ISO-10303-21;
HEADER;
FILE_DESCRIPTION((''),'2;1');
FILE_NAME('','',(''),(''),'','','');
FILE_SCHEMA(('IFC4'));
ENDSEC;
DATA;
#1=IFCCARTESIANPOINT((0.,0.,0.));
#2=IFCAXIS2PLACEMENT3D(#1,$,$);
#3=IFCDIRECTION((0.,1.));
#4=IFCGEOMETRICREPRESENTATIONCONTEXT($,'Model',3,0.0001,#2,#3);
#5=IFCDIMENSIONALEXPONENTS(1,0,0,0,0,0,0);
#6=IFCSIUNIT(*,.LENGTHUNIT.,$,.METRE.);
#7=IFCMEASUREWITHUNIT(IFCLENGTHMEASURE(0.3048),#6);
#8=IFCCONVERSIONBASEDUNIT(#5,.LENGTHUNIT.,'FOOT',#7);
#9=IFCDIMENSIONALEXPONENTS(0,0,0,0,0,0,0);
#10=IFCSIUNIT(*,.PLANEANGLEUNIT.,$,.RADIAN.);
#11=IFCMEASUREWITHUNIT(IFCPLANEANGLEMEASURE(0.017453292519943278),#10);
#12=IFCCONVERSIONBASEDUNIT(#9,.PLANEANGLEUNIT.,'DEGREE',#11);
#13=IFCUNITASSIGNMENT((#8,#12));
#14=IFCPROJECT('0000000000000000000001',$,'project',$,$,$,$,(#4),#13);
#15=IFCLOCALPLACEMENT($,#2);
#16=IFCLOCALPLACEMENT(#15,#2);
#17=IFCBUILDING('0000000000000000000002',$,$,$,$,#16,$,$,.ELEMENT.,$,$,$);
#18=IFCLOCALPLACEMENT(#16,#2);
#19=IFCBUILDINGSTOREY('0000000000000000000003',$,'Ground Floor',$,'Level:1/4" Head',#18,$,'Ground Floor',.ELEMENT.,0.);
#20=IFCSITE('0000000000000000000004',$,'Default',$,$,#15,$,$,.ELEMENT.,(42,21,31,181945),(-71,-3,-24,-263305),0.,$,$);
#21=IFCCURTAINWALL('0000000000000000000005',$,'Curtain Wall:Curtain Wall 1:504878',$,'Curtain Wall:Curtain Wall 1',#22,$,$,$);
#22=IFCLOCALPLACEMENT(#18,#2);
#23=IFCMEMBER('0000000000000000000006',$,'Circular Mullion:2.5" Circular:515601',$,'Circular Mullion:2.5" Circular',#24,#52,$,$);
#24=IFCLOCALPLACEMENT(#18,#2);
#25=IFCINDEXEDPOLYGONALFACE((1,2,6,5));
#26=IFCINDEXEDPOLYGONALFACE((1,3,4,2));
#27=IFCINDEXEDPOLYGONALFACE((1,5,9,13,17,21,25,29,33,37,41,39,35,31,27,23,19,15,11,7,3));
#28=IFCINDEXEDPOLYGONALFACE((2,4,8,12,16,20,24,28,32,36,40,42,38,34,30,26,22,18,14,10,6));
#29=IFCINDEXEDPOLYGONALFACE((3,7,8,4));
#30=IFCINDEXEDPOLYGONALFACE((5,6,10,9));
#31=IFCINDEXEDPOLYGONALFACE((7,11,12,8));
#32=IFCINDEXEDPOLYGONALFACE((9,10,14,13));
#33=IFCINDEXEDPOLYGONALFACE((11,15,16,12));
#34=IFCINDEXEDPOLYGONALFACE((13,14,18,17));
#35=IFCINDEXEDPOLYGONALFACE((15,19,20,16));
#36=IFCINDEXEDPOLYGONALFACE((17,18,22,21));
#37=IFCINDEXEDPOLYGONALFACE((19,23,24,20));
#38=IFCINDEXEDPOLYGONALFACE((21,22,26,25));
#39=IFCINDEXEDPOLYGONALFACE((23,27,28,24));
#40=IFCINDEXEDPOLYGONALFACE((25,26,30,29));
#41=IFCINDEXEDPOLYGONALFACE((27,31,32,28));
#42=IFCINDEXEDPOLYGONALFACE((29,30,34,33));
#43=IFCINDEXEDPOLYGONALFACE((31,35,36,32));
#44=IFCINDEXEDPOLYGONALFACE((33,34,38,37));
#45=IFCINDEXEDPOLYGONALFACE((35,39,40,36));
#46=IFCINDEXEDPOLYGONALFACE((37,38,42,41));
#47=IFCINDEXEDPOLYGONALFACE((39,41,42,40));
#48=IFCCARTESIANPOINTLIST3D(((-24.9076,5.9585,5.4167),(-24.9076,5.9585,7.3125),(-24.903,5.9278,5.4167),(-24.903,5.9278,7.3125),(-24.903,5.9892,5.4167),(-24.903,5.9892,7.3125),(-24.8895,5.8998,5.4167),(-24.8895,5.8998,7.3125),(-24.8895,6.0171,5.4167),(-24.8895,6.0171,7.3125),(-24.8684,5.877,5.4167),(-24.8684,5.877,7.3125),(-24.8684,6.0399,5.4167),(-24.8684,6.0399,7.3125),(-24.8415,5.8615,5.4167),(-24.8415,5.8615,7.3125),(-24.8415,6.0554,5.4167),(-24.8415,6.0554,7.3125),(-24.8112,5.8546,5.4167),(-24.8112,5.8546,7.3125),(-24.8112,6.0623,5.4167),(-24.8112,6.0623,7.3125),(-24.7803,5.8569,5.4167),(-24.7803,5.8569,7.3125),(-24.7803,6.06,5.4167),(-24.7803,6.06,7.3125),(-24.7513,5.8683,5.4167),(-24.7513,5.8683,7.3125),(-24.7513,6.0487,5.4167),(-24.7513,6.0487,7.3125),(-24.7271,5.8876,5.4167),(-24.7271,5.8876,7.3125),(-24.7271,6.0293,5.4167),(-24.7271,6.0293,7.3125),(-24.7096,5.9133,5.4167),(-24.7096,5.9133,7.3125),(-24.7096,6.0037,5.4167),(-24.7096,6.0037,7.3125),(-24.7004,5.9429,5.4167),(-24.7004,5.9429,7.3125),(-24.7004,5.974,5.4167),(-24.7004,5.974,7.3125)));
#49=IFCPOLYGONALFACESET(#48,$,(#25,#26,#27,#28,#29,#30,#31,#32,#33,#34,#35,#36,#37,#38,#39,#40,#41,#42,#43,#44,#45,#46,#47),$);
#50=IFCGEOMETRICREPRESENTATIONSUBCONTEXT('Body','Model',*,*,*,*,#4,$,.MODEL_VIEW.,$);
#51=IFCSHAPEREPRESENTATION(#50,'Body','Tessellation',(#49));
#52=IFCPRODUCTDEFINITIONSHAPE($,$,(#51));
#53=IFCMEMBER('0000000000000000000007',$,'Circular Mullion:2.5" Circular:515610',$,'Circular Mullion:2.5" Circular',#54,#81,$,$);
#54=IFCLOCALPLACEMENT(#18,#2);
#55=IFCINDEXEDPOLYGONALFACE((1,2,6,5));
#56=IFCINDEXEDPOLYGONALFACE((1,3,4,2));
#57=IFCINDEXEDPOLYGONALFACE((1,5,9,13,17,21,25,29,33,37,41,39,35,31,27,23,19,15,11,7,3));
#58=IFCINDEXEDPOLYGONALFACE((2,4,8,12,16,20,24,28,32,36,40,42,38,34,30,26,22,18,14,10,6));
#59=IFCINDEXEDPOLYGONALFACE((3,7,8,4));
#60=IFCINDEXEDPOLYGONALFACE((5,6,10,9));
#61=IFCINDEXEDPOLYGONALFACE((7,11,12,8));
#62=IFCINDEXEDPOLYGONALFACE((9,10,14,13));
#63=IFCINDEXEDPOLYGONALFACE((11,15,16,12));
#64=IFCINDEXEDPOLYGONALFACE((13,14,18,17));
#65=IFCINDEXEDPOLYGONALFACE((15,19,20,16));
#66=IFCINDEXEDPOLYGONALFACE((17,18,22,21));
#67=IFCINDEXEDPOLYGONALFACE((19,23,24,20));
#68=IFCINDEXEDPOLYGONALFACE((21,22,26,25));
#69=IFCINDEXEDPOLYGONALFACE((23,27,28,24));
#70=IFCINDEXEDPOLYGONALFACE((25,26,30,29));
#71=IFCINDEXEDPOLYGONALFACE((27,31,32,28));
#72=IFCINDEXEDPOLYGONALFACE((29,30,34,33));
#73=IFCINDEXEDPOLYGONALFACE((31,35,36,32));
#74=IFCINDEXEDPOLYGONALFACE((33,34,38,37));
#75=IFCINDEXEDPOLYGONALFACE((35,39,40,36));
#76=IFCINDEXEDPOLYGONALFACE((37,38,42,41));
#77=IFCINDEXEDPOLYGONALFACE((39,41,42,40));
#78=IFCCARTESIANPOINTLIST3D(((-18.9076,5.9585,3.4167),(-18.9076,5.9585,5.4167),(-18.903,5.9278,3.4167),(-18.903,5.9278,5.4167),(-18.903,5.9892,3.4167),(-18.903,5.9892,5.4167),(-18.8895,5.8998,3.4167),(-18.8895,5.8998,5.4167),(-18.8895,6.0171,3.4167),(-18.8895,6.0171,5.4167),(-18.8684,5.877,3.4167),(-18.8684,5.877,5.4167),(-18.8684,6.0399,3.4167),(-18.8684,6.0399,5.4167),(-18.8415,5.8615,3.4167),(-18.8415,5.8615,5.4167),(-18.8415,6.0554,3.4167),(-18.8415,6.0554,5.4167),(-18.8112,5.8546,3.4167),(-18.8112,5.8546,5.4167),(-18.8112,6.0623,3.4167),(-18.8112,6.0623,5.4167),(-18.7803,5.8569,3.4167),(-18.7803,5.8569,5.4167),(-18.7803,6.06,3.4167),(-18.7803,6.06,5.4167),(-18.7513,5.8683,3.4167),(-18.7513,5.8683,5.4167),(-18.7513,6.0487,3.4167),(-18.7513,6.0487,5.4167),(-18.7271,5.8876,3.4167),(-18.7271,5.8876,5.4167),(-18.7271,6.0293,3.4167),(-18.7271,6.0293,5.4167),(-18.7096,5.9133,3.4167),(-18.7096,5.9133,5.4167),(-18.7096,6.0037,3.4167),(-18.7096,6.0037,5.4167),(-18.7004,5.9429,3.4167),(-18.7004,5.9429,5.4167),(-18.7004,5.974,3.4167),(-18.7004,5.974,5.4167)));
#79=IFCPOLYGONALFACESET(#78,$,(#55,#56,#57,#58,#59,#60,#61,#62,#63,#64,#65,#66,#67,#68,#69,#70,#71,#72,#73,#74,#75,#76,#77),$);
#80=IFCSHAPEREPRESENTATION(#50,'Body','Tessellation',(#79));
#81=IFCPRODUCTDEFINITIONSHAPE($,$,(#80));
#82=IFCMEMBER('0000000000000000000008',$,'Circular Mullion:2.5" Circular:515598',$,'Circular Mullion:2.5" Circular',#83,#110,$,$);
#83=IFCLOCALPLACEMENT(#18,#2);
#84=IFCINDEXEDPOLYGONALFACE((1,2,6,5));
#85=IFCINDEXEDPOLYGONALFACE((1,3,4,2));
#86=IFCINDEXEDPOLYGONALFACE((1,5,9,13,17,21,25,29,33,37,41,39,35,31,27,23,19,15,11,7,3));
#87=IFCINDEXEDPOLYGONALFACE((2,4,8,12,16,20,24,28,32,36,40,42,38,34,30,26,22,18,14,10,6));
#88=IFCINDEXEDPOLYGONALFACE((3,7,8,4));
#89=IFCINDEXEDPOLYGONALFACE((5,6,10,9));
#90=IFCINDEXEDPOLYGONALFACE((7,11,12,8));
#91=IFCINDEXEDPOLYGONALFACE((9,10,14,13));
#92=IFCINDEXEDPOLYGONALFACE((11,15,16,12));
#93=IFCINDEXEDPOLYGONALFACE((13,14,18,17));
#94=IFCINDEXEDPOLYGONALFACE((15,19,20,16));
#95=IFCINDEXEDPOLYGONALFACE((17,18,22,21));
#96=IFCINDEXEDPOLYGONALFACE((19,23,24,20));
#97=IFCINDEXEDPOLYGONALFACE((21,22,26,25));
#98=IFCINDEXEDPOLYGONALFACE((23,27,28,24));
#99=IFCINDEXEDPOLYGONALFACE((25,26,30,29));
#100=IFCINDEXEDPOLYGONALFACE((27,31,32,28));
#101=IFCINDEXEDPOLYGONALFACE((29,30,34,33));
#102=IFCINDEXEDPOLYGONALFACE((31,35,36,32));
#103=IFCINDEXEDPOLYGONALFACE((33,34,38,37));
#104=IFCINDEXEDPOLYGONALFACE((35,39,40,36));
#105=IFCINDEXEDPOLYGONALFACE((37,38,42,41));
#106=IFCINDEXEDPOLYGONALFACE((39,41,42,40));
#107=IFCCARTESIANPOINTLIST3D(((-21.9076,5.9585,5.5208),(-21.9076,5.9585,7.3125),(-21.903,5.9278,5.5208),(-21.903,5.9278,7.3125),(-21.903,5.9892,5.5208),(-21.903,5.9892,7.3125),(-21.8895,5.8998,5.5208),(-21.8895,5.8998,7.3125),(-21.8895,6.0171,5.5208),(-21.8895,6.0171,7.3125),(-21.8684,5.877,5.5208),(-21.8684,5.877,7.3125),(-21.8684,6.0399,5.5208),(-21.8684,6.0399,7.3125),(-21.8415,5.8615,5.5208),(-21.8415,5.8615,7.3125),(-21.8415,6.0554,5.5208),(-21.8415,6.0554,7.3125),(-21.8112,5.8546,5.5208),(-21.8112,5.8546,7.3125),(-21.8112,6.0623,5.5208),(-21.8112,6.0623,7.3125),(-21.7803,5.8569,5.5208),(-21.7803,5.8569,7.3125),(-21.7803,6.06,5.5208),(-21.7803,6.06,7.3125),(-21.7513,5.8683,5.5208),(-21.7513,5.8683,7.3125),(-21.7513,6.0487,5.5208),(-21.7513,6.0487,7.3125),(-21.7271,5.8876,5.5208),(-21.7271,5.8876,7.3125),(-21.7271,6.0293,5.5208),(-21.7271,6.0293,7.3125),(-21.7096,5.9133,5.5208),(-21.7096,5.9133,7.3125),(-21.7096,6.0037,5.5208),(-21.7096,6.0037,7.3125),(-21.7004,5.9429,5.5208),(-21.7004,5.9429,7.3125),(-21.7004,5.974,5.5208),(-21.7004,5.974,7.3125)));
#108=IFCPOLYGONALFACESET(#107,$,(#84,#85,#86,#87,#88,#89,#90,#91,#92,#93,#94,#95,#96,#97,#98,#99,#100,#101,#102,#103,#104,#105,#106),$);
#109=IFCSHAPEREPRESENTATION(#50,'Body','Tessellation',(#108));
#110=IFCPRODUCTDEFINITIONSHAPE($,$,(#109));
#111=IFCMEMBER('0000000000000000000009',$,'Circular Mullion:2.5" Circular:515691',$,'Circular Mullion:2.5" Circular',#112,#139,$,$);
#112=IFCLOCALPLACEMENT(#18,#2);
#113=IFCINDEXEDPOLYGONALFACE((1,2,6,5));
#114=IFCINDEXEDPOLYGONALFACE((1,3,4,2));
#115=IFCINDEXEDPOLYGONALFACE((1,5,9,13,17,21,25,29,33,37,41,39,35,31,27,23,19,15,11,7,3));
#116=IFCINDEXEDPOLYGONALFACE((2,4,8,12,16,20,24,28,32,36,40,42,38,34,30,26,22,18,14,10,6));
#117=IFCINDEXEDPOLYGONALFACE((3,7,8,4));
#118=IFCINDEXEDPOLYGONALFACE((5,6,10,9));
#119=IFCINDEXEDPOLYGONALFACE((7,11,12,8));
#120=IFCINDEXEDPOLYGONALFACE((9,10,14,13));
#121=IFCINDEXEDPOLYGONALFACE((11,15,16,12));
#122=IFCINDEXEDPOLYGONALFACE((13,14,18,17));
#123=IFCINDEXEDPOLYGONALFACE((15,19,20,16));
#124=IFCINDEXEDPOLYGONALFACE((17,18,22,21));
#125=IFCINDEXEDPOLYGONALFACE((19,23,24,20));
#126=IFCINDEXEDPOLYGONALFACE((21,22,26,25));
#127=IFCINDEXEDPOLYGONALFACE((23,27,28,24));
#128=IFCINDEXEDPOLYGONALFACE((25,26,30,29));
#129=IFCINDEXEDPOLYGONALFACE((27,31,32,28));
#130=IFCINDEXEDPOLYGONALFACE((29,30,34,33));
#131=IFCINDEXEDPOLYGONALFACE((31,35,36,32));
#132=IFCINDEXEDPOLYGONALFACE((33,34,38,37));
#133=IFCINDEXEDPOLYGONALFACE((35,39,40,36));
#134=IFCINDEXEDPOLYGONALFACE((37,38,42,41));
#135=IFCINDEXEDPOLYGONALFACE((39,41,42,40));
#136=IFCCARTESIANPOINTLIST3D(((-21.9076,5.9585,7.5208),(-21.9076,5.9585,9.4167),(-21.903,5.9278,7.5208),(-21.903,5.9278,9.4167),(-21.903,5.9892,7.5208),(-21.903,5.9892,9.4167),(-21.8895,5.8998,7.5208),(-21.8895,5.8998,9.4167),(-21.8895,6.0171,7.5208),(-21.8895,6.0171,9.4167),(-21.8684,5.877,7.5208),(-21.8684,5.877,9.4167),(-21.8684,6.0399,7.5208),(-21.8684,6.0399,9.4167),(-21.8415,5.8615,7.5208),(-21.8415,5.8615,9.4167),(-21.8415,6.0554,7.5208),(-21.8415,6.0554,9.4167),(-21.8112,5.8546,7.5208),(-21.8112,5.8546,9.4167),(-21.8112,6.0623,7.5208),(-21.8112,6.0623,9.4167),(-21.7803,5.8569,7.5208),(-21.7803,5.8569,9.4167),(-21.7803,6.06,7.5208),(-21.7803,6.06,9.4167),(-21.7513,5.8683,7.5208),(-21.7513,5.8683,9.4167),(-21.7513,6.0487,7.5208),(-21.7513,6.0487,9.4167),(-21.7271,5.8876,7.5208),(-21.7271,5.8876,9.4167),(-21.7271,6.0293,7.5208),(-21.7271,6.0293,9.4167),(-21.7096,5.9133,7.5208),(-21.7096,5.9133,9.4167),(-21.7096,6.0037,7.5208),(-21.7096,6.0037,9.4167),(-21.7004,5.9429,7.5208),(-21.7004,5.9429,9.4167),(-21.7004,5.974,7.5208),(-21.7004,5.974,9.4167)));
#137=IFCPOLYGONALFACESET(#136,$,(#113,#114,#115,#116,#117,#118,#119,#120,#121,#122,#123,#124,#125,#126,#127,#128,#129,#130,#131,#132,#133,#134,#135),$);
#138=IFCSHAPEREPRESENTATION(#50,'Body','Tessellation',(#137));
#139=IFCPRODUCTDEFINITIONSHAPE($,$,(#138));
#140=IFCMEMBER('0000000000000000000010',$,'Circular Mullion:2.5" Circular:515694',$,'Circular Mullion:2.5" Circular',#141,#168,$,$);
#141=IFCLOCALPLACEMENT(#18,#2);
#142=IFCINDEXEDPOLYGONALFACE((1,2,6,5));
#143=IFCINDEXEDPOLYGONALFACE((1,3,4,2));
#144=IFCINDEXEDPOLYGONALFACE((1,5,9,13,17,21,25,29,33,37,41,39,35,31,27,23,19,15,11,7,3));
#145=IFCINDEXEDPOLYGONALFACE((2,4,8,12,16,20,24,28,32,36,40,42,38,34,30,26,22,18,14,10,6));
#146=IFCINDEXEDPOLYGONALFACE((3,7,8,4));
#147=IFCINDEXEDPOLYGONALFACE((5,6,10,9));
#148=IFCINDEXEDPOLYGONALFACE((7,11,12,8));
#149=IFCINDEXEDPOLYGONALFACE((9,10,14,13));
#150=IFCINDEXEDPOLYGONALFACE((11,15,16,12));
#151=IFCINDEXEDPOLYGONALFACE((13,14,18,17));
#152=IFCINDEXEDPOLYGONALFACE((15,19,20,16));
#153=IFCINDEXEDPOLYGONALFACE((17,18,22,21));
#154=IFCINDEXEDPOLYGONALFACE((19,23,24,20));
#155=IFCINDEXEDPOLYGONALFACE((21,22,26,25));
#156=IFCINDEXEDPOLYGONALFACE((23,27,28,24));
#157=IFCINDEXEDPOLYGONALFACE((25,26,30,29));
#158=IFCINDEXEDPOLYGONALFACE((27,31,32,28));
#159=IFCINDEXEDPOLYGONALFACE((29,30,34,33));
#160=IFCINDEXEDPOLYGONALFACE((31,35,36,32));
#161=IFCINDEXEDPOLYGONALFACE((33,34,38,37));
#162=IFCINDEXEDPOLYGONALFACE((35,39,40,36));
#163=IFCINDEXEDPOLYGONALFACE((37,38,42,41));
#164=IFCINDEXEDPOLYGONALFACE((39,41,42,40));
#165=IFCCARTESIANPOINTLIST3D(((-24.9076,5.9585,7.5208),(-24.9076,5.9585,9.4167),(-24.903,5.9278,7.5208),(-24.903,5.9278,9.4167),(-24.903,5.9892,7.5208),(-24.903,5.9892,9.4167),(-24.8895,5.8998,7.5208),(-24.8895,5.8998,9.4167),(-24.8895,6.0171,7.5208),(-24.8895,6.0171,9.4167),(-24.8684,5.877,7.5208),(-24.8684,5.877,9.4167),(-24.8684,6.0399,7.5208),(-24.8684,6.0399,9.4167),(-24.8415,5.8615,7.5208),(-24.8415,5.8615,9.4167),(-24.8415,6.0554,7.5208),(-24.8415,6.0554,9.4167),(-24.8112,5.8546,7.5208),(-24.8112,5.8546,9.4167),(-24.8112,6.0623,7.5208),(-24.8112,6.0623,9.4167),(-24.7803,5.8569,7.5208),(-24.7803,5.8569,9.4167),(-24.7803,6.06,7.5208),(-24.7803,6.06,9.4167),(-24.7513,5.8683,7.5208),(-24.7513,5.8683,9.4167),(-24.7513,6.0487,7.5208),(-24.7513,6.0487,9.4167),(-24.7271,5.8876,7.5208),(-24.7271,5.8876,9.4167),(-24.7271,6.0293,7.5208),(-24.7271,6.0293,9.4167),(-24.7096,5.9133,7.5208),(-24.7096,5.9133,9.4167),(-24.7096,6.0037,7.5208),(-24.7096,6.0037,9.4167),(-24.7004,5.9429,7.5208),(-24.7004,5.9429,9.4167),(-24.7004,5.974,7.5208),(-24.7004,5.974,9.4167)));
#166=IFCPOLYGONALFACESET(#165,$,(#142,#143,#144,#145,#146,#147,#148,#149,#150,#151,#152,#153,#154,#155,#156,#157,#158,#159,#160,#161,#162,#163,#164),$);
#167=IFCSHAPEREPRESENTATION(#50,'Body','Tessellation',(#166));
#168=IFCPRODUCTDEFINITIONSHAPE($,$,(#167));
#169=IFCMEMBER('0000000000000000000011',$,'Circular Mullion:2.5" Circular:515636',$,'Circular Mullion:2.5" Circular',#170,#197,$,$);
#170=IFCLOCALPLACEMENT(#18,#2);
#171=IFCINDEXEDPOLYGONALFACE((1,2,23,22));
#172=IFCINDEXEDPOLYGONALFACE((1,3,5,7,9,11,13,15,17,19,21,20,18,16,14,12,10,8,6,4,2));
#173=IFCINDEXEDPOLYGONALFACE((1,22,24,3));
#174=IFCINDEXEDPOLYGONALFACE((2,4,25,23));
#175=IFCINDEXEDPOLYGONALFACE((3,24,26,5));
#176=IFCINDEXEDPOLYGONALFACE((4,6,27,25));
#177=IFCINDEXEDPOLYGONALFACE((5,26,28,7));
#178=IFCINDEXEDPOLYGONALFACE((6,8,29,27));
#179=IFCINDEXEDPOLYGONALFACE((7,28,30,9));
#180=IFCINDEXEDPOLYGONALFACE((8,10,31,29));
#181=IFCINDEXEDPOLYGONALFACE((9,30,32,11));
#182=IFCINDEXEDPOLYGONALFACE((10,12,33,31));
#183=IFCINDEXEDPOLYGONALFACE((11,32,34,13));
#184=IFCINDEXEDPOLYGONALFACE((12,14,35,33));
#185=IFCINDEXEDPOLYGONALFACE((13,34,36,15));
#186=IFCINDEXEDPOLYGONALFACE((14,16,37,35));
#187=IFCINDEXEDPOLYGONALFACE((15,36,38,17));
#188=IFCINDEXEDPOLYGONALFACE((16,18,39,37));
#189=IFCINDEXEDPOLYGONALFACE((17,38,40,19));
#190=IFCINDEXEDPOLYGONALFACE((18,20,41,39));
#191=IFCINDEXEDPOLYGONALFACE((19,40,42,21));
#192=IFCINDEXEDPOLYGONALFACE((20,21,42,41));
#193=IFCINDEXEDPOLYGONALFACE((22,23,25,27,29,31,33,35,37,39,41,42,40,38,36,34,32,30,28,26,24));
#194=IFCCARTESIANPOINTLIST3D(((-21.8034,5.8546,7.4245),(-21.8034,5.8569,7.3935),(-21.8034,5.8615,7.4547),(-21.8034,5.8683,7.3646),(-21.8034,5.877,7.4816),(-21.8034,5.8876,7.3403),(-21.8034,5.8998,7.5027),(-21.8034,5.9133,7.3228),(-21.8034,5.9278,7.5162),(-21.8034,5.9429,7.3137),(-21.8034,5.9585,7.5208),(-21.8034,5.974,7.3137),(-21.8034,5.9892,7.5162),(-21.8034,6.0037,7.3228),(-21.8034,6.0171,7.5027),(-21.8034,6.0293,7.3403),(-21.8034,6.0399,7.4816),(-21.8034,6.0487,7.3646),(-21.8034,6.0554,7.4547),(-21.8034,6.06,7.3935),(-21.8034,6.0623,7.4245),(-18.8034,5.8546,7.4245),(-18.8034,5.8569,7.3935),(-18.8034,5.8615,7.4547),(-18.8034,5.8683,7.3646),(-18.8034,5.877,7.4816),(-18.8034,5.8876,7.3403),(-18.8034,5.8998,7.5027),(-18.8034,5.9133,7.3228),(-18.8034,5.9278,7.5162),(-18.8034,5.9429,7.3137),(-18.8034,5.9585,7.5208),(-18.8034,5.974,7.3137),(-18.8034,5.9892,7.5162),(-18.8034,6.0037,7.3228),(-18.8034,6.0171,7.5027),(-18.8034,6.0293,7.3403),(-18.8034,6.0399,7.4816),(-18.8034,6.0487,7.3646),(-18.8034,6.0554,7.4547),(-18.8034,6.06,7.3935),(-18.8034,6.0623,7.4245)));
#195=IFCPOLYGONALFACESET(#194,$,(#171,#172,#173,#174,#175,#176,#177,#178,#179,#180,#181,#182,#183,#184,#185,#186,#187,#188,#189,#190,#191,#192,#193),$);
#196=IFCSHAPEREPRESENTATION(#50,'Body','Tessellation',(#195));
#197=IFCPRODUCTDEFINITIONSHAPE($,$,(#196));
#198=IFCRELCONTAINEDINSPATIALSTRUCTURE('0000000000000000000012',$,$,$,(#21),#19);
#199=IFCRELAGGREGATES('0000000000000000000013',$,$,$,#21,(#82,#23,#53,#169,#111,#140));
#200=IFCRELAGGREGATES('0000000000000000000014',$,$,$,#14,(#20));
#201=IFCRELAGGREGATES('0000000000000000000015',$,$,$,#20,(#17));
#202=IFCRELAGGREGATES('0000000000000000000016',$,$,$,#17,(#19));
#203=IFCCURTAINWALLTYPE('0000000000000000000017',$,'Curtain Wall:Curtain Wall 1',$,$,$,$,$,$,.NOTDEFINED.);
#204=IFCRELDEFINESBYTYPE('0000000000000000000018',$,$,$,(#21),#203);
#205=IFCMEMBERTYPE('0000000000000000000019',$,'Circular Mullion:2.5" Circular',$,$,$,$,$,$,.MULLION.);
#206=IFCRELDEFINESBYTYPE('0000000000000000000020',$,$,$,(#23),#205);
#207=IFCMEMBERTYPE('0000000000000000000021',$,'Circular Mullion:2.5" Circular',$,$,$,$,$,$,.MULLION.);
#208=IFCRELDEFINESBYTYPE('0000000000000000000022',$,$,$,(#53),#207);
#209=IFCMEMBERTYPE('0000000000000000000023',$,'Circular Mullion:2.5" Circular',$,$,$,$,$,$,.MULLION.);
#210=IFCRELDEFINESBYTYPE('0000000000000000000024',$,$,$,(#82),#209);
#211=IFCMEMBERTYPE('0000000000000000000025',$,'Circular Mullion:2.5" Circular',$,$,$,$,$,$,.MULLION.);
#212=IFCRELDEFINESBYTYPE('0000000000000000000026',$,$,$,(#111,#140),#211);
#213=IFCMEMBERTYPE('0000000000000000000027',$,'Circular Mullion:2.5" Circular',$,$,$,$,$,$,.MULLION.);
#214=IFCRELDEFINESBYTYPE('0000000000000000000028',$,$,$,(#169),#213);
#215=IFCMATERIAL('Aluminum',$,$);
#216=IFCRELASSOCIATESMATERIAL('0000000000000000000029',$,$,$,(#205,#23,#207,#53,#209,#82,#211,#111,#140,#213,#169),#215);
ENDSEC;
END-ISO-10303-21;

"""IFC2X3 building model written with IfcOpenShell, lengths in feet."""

from ifc_helpers import new_model, entity, si_unit, converted_unit, direction, frame, frame_2d, origin, place, context, subcontext, project, spatial, circle, extrude, source, transform, mapped, material, type_object, type_shapes, element, aggregate, save


model = new_model("IFC2X3")

# Units and contexts
model_context = context("Model", 3, precision=0.0001, world=origin(), true_north=direction((0.0, 1.0)))
body_context = subcontext(model_context, "Body", "Model", "MODEL_VIEW")
ifc_project = project(units=[converted_unit("LENGTHUNIT", "FOOT", entity("IfcLengthMeasure", 0.3048), si_unit("LENGTHUNIT", "METRE"), dimensions=[1, 0, 0, 0, 0, 0, 0]), converted_unit("PLANEANGLEUNIT", "DEGREE", entity("IfcPlaneAngleMeasure", 0.017453292519943278), si_unit("PLANEANGLEUNIT", "RADIAN"), dimensions=[0, 0, 0, 0, 0, 0, 0])], contexts=[model_context])

# Site, building, storey
site_placement = place(None, origin())
site = spatial("IfcSite", under=ifc_project, at=site_placement, Name="Default", CompositionType="ELEMENT", RefLatitude=(42, 21, 31, 181945), RefLongitude=(-71, -3, -24, -263305), RefElevation=0.0)
building_placement = place(site_placement, origin())
building = spatial("IfcBuilding", under=site, at=building_placement, CompositionType="ELEMENT")
storey_placement = place(building_placement, origin())
storey = spatial("IfcBuildingStorey", under=building, at=storey_placement, Name="Ground Floor", ObjectType="Level:1/4\" Head", LongName="Ground Floor", CompositionType="ELEMENT", Elevation=0.0)

# Curtain wall, members
curtain_wall_type = type_object("IfcCurtainWallType", Name="Curtain Wall:Curtain Wall 1", PredefinedType="NOTDEFINED")
curtain_wall_placement = place(storey_placement, origin())
curtain_wall = element("IfcCurtainWall", 1, at=curtain_wall_placement, inside=storey, type_object=curtain_wall_type, Name="Curtain Wall:Curtain Wall 1:504878", ObjectType="Curtain Wall:Curtain Wall 1")
ifc_material_1 = material(Name="Aluminum")
member_type_1 = type_object("IfcMemberType", Name="Circular Mullion:2.5\" Circular", PredefinedType="MULLION", material=ifc_material_1)
shared_shape_1 = source(origin(), body_context, "Body", "SweptSolid", [
    extrude(circle(Radius=0.1042, at=frame_2d((0.0, 0.0), x_axis=(1.0, 0.0))), frame((0.0, 0.0, -1.8958)), (0.0, 0.0, 1.0), 1.8958),
])
type_shapes(member_type_1, [shared_shape_1])
member_1_placement = place(curtain_wall_placement, frame((-24.8034, 5.9585, 5.4167), z_axis=(0.0, 0.0, -1.0), x_axis=(-1.0, 0.0, 0.0)))
member_1 = element("IfcMember", 2, at=member_1_placement, type_object=member_type_1, material=ifc_material_1, Name="Circular Mullion:2.5\" Circular:515601", ObjectType="Circular Mullion:2.5\" Circular", context=body_context, shape_type="MappedRepresentation", body=[
    mapped(shared_shape_1, transform((0.0, 0.0, 0.0), scale=1.0)),
])
member_type_2 = type_object("IfcMemberType", Name="Circular Mullion:2.5\" Circular", PredefinedType="MULLION", material=ifc_material_1)
shared_shape_2 = source(origin(), body_context, "Body", "SweptSolid", [
    extrude(circle(Radius=0.1042, at=frame_2d((0.0, 0.0), x_axis=(1.0, 0.0))), frame((0.0, 0.0, -2.0)), (0.0, 0.0, 1.0), 2.0),
])
type_shapes(member_type_2, [shared_shape_2])
member_2_placement = place(curtain_wall_placement, frame((-18.8034, 5.9585, 3.4167), z_axis=(0.0, 0.0, -1.0), x_axis=(-1.0, 0.0, 0.0)))
member_2 = element("IfcMember", 3, at=member_2_placement, type_object=member_type_2, material=ifc_material_1, Name="Circular Mullion:2.5\" Circular:515610", ObjectType="Circular Mullion:2.5\" Circular", context=body_context, shape_type="MappedRepresentation", body=[
    mapped(shared_shape_2, transform((0.0, 0.0, 0.0), scale=1.0)),
])
member_type_3 = type_object("IfcMemberType", Name="Circular Mullion:2.5\" Circular", PredefinedType="MULLION", material=ifc_material_1)
shared_shape_3 = source(origin(), body_context, "Body", "SweptSolid", [
    extrude(circle(Radius=0.1042, at=frame_2d((0.0, 0.0), x_axis=(1.0, 0.0))), frame((0.0, 0.0, -1.7917)), (0.0, 0.0, 1.0), 1.7917),
])
type_shapes(member_type_3, [shared_shape_3])
member_3_placement = place(curtain_wall_placement, frame((-21.8034, 5.9585, 5.5208), z_axis=(0.0, 0.0, -1.0), x_axis=(-1.0, 0.0, 0.0)))
member_3 = element("IfcMember", 4, at=member_3_placement, type_object=member_type_3, material=ifc_material_1, Name="Circular Mullion:2.5\" Circular:515598", ObjectType="Circular Mullion:2.5\" Circular", context=body_context, shape_type="MappedRepresentation", body=[
    mapped(shared_shape_3, transform((0.0, 0.0, 0.0), scale=1.0)),
])
member_type_4 = type_object("IfcMemberType", Name="Circular Mullion:2.5\" Circular", PredefinedType="MULLION", material=ifc_material_1)
shared_shape_4 = source(origin(), body_context, "Body", "SweptSolid", [
    extrude(circle(Radius=0.1042, at=frame_2d((0.0, 0.0), x_axis=(1.0, 0.0))), frame((0.0, 0.0, -1.8958)), (0.0, 0.0, 1.0), 1.8958),
])
type_shapes(member_type_4, [shared_shape_4])
member_4_placement = place(curtain_wall_placement, frame((-21.8034, 5.9585, 7.5208), z_axis=(0.0, 0.0, -1.0), x_axis=(-1.0, 0.0, 0.0)))
member_4 = element("IfcMember", 5, at=member_4_placement, type_object=member_type_4, material=ifc_material_1, Name="Circular Mullion:2.5\" Circular:515691", ObjectType="Circular Mullion:2.5\" Circular", context=body_context, shape_type="MappedRepresentation", body=[
    mapped(shared_shape_4, transform((0.0, 0.0, 0.0), scale=1.0)),
])
member_5_placement = place(curtain_wall_placement, frame((-24.8034, 5.9585, 7.5208), z_axis=(0.0, 0.0, -1.0), x_axis=(-1.0, 0.0, 0.0)))
member_5 = element("IfcMember", 6, at=member_5_placement, type_object=member_type_4, material=ifc_material_1, Name="Circular Mullion:2.5\" Circular:515694", ObjectType="Circular Mullion:2.5\" Circular", context=body_context, shape_type="MappedRepresentation", body=[
    mapped(shared_shape_4, transform((0.0, 0.0, 0.0), scale=1.0)),
])
member_type_5 = type_object("IfcMemberType", Name="Circular Mullion:2.5\" Circular", PredefinedType="MULLION", material=ifc_material_1)
shared_shape_5 = source(origin(), body_context, "Body", "SweptSolid", [
    extrude(circle(Radius=0.1042, at=frame_2d((0.0, 0.0), x_axis=(1.0, 0.0))), frame((0.0, 0.0, -3.0)), (0.0, 0.0, 1.0), 3.0),
])
type_shapes(member_type_5, [shared_shape_5])
member_6_placement = place(curtain_wall_placement, frame((-21.8034, 5.9585, 7.4167), z_axis=(-1.0, 0.0, 0.0), x_axis=(0.0, 0.0, 1.0)))
member_6 = element("IfcMember", 7, at=member_6_placement, type_object=member_type_5, material=ifc_material_1, Name="Circular Mullion:2.5\" Circular:515636", ObjectType="Circular Mullion:2.5\" Circular", context=body_context, shape_type="MappedRepresentation", body=[
    mapped(shared_shape_5, transform((0.0, 0.0, 0.0), scale=1.0)),
])
aggregate(curtain_wall, [member_3, member_1, member_2, member_6, member_4, member_5])

save(model, "model.ifc")
